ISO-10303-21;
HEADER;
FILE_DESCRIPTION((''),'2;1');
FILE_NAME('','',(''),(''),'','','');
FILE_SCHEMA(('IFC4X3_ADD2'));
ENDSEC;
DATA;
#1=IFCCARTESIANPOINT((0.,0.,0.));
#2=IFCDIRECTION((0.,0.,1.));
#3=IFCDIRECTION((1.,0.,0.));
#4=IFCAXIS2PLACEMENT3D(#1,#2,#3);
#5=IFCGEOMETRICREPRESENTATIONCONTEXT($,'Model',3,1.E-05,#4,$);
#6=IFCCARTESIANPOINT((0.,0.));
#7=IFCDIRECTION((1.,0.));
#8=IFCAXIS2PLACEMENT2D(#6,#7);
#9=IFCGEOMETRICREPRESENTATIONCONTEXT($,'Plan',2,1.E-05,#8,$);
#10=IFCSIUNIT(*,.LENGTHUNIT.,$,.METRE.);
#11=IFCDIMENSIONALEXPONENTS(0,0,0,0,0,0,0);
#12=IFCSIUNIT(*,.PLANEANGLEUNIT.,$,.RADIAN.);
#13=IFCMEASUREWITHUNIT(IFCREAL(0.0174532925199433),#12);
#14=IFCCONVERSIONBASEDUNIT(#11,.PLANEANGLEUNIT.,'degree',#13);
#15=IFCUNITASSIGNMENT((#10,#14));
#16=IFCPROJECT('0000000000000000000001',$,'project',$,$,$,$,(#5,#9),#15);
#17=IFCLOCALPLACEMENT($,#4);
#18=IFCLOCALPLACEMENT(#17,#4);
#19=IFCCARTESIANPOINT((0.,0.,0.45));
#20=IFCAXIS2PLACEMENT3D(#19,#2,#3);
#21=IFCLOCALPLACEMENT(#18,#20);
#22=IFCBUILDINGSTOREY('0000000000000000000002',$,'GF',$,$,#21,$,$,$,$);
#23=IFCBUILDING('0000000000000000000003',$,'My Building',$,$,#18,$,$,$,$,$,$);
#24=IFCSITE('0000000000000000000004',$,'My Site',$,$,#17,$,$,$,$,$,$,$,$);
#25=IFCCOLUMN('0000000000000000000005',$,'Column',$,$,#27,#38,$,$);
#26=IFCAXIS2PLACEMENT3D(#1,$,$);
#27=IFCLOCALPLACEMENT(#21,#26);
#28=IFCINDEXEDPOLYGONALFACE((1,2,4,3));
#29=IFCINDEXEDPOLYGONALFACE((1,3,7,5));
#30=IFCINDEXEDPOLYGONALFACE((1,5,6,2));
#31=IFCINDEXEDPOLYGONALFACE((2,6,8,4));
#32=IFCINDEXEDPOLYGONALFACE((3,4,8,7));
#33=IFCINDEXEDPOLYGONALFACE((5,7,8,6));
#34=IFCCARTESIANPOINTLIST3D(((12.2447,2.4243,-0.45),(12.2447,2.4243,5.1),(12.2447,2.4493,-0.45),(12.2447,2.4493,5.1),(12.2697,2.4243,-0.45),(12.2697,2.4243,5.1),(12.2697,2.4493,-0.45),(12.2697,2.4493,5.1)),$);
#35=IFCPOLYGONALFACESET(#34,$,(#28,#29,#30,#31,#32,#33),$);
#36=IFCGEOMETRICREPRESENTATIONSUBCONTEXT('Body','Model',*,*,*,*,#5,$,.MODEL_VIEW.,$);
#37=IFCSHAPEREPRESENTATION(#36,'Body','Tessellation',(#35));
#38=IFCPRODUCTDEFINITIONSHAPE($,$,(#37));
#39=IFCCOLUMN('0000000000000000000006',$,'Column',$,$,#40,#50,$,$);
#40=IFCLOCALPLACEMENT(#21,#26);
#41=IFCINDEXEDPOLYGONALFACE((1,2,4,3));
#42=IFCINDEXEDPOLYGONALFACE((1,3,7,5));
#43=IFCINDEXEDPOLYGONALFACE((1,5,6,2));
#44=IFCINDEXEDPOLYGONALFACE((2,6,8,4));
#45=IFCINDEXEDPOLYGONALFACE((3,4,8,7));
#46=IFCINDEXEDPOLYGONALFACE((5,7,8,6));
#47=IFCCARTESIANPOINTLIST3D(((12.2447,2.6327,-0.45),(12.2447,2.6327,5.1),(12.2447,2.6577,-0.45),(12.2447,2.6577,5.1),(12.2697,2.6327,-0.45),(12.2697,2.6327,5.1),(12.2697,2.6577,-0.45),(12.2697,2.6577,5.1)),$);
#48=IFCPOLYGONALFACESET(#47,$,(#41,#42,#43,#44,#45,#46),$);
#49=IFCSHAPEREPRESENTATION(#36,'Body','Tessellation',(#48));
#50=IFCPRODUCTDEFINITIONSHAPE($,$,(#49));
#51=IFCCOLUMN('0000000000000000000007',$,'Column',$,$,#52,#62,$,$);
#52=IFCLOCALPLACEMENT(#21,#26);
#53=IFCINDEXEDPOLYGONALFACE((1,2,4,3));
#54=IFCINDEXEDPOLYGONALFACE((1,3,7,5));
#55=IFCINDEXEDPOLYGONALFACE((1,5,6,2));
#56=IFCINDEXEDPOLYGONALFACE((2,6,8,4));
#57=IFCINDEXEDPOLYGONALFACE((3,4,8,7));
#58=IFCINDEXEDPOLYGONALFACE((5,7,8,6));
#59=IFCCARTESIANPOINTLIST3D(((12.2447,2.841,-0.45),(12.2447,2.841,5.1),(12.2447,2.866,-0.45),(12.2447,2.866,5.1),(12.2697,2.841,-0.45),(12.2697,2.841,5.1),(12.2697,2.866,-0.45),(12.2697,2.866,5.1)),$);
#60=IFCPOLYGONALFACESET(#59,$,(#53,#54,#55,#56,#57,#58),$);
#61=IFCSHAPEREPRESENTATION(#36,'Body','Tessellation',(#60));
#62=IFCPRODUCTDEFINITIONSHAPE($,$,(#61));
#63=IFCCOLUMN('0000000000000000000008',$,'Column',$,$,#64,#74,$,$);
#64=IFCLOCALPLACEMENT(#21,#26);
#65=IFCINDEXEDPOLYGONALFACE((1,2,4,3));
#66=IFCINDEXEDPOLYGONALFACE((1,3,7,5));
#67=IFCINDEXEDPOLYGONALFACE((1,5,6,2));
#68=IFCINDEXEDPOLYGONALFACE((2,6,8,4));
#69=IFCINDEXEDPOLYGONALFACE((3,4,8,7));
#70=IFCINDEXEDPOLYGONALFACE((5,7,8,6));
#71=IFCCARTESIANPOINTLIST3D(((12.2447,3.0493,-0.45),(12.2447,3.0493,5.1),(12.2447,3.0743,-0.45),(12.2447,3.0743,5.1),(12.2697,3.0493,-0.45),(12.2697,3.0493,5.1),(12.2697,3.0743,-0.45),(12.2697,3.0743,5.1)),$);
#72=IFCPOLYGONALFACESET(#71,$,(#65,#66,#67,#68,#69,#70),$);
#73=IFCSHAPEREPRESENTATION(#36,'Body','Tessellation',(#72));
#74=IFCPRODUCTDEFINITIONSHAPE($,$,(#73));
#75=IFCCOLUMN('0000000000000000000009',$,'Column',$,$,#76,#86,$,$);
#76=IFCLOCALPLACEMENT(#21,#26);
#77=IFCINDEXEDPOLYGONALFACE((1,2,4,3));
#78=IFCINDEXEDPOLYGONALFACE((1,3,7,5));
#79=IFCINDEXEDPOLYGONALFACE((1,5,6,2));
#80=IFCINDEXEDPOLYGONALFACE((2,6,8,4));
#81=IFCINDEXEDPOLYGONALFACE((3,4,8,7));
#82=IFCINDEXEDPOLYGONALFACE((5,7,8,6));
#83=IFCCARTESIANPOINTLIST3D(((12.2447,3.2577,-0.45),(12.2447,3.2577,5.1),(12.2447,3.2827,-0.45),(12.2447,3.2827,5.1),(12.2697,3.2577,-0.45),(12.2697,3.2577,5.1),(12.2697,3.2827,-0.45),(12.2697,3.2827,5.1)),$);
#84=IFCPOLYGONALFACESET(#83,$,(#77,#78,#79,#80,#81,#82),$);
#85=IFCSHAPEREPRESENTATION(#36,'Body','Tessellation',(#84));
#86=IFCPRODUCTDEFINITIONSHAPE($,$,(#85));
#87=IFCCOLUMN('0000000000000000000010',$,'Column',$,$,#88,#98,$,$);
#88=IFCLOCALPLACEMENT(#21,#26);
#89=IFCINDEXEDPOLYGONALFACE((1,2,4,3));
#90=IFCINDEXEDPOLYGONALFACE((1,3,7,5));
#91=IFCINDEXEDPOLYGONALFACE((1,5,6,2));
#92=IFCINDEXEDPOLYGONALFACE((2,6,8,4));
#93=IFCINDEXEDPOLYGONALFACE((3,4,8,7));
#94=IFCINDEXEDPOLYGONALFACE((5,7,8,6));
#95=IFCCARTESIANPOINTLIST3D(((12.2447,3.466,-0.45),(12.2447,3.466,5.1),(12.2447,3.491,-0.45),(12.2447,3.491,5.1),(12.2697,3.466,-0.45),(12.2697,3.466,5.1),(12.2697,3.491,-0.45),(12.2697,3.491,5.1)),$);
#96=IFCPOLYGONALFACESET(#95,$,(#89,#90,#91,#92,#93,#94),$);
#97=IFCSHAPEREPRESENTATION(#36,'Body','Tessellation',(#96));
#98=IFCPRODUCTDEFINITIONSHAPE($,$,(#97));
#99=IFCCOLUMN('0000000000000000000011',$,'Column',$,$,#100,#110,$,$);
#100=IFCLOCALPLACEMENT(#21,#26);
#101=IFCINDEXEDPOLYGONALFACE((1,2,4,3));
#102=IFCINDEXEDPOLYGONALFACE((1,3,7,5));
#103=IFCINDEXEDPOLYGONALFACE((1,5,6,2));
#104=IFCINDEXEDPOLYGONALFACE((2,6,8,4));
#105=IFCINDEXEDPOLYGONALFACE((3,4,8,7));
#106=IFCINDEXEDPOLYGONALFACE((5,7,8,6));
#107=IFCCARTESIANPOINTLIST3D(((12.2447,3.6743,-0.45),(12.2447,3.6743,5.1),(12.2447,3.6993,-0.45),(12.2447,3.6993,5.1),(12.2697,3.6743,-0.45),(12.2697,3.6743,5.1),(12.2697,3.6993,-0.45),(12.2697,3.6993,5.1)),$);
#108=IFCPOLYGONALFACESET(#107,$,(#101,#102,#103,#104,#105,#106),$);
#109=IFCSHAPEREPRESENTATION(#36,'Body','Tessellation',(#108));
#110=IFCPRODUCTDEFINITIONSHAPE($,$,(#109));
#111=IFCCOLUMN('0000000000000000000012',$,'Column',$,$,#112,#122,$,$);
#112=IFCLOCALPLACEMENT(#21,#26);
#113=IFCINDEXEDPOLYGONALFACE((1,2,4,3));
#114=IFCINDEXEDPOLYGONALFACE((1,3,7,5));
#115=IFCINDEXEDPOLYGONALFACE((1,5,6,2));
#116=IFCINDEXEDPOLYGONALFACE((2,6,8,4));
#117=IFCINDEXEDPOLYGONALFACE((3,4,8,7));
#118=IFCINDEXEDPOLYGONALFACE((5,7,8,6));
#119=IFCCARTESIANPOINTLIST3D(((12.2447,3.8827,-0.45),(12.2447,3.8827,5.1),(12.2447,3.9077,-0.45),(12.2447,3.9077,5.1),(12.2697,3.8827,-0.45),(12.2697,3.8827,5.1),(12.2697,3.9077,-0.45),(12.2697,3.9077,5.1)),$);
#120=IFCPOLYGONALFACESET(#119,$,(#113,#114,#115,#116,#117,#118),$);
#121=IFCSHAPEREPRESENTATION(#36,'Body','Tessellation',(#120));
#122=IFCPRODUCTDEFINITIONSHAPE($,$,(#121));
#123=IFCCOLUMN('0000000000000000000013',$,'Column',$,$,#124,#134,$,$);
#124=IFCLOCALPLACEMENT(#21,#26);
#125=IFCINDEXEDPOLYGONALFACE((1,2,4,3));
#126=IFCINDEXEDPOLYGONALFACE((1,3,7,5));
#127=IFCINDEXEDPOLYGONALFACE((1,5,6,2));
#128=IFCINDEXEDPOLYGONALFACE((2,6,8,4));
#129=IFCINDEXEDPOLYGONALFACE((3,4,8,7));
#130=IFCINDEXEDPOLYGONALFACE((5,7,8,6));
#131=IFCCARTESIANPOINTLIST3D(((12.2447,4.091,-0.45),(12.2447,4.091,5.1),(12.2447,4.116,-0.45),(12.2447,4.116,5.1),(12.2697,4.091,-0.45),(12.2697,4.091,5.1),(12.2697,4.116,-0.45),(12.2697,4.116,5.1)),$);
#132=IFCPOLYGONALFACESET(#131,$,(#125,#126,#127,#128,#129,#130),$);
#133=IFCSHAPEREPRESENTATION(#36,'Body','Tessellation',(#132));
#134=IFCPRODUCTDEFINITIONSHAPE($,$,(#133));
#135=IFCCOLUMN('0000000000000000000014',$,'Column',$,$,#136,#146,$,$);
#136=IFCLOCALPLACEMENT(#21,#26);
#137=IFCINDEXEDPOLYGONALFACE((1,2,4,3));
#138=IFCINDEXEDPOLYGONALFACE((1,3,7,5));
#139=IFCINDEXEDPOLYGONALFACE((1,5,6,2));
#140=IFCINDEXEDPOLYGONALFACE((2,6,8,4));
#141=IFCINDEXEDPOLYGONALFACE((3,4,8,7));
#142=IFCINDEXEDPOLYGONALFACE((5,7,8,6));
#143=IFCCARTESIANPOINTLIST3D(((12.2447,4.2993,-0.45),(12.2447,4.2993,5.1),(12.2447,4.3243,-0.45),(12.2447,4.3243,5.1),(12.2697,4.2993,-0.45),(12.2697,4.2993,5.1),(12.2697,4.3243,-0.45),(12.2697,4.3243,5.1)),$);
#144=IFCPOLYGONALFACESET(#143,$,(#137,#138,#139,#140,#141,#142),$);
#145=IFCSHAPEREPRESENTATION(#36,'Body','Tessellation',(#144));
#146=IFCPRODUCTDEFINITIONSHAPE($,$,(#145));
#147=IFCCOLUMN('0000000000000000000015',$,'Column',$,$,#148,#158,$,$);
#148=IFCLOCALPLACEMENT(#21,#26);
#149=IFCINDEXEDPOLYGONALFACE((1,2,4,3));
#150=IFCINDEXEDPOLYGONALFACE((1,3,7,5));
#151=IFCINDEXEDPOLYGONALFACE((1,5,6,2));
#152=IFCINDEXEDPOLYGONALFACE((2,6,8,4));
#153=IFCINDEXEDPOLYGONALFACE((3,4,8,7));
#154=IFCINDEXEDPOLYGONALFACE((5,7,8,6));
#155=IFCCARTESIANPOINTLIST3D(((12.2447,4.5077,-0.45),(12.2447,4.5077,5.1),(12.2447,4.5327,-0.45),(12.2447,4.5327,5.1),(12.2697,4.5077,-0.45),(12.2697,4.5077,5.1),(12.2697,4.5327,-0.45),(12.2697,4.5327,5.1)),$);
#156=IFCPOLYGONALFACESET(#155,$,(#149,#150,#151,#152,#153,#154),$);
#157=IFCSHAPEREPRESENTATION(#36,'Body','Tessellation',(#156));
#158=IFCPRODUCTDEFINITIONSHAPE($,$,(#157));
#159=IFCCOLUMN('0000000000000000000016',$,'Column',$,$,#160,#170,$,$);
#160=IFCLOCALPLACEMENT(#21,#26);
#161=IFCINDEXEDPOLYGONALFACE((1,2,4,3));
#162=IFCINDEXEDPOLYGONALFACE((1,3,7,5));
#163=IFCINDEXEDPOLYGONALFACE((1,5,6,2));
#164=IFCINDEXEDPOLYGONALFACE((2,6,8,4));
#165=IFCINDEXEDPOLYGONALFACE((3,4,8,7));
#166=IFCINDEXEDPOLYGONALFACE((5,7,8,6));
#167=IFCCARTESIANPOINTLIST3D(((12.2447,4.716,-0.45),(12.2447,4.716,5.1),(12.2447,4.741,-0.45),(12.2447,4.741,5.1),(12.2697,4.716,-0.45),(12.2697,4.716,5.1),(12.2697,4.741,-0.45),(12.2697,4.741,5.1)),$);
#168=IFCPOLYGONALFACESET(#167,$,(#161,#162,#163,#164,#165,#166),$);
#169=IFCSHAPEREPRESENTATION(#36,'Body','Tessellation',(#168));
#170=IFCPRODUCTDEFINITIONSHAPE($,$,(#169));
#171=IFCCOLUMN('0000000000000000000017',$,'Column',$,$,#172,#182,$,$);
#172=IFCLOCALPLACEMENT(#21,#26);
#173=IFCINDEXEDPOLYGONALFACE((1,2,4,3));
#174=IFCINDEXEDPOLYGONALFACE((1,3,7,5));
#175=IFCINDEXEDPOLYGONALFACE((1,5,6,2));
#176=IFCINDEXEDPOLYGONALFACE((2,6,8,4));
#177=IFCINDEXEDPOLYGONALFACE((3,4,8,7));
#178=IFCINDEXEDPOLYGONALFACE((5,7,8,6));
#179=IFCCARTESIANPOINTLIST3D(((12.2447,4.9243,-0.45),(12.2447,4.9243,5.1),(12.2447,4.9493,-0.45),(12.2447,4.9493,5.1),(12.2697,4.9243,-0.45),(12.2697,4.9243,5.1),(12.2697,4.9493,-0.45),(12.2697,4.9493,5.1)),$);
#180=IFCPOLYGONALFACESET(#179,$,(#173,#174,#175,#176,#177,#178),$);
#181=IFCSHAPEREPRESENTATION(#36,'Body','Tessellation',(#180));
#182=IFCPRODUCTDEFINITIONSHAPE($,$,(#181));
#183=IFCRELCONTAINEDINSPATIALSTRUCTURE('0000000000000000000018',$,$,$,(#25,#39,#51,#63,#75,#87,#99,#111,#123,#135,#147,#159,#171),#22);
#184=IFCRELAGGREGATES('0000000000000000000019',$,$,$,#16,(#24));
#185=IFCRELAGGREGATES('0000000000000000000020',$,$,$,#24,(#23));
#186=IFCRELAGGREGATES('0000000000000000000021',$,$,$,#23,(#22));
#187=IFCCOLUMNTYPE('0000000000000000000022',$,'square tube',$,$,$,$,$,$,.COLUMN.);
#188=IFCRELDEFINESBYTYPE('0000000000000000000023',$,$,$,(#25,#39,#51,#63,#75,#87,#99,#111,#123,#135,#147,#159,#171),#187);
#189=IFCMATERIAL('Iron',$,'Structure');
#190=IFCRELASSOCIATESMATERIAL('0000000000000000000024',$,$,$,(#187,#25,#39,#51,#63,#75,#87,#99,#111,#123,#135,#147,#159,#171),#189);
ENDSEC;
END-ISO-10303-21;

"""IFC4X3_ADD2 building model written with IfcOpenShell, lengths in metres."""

from ifc_helpers import new_model, entity, si_unit, converted_unit, frame, origin_with_axes, origin_2d_with_axis, place, context, subcontext, project, spatial, indexed_curve, outline, extrude, material, material_profile, profile_set, profile_usage, type_object, element, save


model = new_model("IFC4X3_ADD2")

# Units and contexts
model_context = context("Model", 3, precision=1e-05, world=origin_with_axes())
plan_context = context("Plan", 2, precision=1e-05, world=origin_2d_with_axis())
body_context = subcontext(model_context, "Body", "Model", "MODEL_VIEW")
ifc_project = project(units=[si_unit("LENGTHUNIT", "METRE"), converted_unit("PLANEANGLEUNIT", "degree", entity("IfcReal", 0.0174532925199433), si_unit("PLANEANGLEUNIT", "RADIAN"), dimensions=[0, 0, 0, 0, 0, 0, 0])], contexts=[model_context, plan_context])

# Site, building, storey
site_placement = place(None, origin_with_axes())
site = spatial("IfcSite", under=ifc_project, at=site_placement, Name="My Site")
building_placement = place(site_placement, origin_with_axes())
building = spatial("IfcBuilding", under=site, at=building_placement, Name="My Building")
storey_placement = place(building_placement, frame((0.0, 0.0, 0.45), z_axis=(0.0, 0.0, 1.0), x_axis=(1.0, 0.0, 0.0)))
storey = spatial("IfcBuildingStorey", under=building, at=storey_placement, Name="GF")

# Columns
ifc_material_1 = material(Name="Iron", Category="Structure")
ifc_material_profile = material_profile(ifc_material_1, outline(indexed_curve([(-0.0125, -0.0125), (0.0125, -0.0125), (0.0125, 0.0125), (-0.0125, 0.0125), (-0.0125, -0.0125)])))
ifc_profile_set = profile_set([ifc_material_profile])
ifc_profile_usage_1 = profile_usage(ifc_profile_set, cardinal=5)
column_type = type_object("IfcColumnType", Name="square tube", PredefinedType="COLUMN", material=ifc_profile_set)
column_1_placement = place(storey_placement, frame((12.2572, 2.4368, -0.45), z_axis=(0.0, 0.0, 1.0), x_axis=(0.0, 1.0, 0.0)))
element("IfcColumn", 1, at=column_1_placement, inside=storey, type_object=column_type, material=ifc_profile_usage_1, Name="Column", context=body_context, shape_type="SweptSolid", body=[
    extrude(outline(indexed_curve([(-0.0125, -0.0125), (0.0125, -0.0125), (0.0125, 0.0125), (-0.0125, 0.0125), (-0.0125, -0.0125)])), origin_with_axes(), (0.0, 0.0, 1.0), 5.55),
])
ifc_profile_usage_2 = profile_usage(ifc_profile_set, cardinal=5)
column_2_placement = place(storey_placement, frame((12.2572, 2.6452, -0.45), z_axis=(0.0, 0.0, 1.0), x_axis=(0.0, 1.0, 0.0)))
element("IfcColumn", 2, at=column_2_placement, inside=storey, type_object=column_type, material=ifc_profile_usage_2, Name="Column", context=body_context, shape_type="SweptSolid", body=[
    extrude(outline(indexed_curve([(-0.0125, -0.0125), (0.0125, -0.0125), (0.0125, 0.0125), (-0.0125, 0.0125), (-0.0125, -0.0125)])), origin_with_axes(), (0.0, 0.0, 1.0), 5.55),
])
ifc_profile_usage_3 = profile_usage(ifc_profile_set, cardinal=5)
column_3_placement = place(storey_placement, frame((12.2572, 2.8535, -0.45), z_axis=(0.0, 0.0, 1.0), x_axis=(0.0, 1.0, 0.0)))
element("IfcColumn", 3, at=column_3_placement, inside=storey, type_object=column_type, material=ifc_profile_usage_3, Name="Column", context=body_context, shape_type="SweptSolid", body=[
    extrude(outline(indexed_curve([(-0.0125, -0.0125), (0.0125, -0.0125), (0.0125, 0.0125), (-0.0125, 0.0125), (-0.0125, -0.0125)])), origin_with_axes(), (0.0, 0.0, 1.0), 5.55),
])
ifc_profile_usage_4 = profile_usage(ifc_profile_set, cardinal=5)
column_4_placement = place(storey_placement, frame((12.2572, 3.0618, -0.45), z_axis=(0.0, 0.0, 1.0), x_axis=(0.0, 1.0, 0.0)))
element("IfcColumn", 4, at=column_4_placement, inside=storey, type_object=column_type, material=ifc_profile_usage_4, Name="Column", context=body_context, shape_type="SweptSolid", body=[
    extrude(outline(indexed_curve([(-0.0125, -0.0125), (0.0125, -0.0125), (0.0125, 0.0125), (-0.0125, 0.0125), (-0.0125, -0.0125)])), origin_with_axes(), (0.0, 0.0, 1.0), 5.55),
])
ifc_profile_usage_5 = profile_usage(ifc_profile_set, cardinal=5)
column_5_placement = place(storey_placement, frame((12.2572, 3.2702, -0.45), z_axis=(0.0, 0.0, 1.0), x_axis=(0.0, 1.0, 0.0)))
element("IfcColumn", 5, at=column_5_placement, inside=storey, type_object=column_type, material=ifc_profile_usage_5, Name="Column", context=body_context, shape_type="SweptSolid", body=[
    extrude(outline(indexed_curve([(-0.0125, -0.0125), (0.0125, -0.0125), (0.0125, 0.0125), (-0.0125, 0.0125), (-0.0125, -0.0125)])), origin_with_axes(), (0.0, 0.0, 1.0), 5.55),
])
ifc_profile_usage_6 = profile_usage(ifc_profile_set, cardinal=5)
column_6_placement = place(storey_placement, frame((12.2572, 3.4785, -0.45), z_axis=(0.0, 0.0, 1.0), x_axis=(0.0, 1.0, 0.0)))
element("IfcColumn", 6, at=column_6_placement, inside=storey, type_object=column_type, material=ifc_profile_usage_6, Name="Column", context=body_context, shape_type="SweptSolid", body=[
    extrude(outline(indexed_curve([(-0.0125, -0.0125), (0.0125, -0.0125), (0.0125, 0.0125), (-0.0125, 0.0125), (-0.0125, -0.0125)])), origin_with_axes(), (0.0, 0.0, 1.0), 5.55),
])
ifc_profile_usage_7 = profile_usage(ifc_profile_set, cardinal=5)
column_7_placement = place(storey_placement, frame((12.2572, 3.6868, -0.45), z_axis=(0.0, 0.0, 1.0), x_axis=(0.0, 1.0, 0.0)))
element("IfcColumn", 7, at=column_7_placement, inside=storey, type_object=column_type, material=ifc_profile_usage_7, Name="Column", context=body_context, shape_type="SweptSolid", body=[
    extrude(outline(indexed_curve([(-0.0125, -0.0125), (0.0125, -0.0125), (0.0125, 0.0125), (-0.0125, 0.0125), (-0.0125, -0.0125)])), origin_with_axes(), (0.0, 0.0, 1.0), 5.55),
])
ifc_profile_usage_8 = profile_usage(ifc_profile_set, cardinal=5)
column_8_placement = place(storey_placement, frame((12.2572, 3.8952, -0.45), z_axis=(0.0, 0.0, 1.0), x_axis=(0.0, 1.0, 0.0)))
element("IfcColumn", 8, at=column_8_placement, inside=storey, type_object=column_type, material=ifc_profile_usage_8, Name="Column", context=body_context, shape_type="SweptSolid", body=[
    extrude(outline(indexed_curve([(-0.0125, -0.0125), (0.0125, -0.0125), (0.0125, 0.0125), (-0.0125, 0.0125), (-0.0125, -0.0125)])), origin_with_axes(), (0.0, 0.0, 1.0), 5.55),
])
ifc_profile_usage_9 = profile_usage(ifc_profile_set, cardinal=5)
column_9_placement = place(storey_placement, frame((12.2572, 4.1035, -0.45), z_axis=(0.0, 0.0, 1.0), x_axis=(0.0, 1.0, 0.0)))
element("IfcColumn", 9, at=column_9_placement, inside=storey, type_object=column_type, material=ifc_profile_usage_9, Name="Column", context=body_context, shape_type="SweptSolid", body=[
    extrude(outline(indexed_curve([(-0.0125, -0.0125), (0.0125, -0.0125), (0.0125, 0.0125), (-0.0125, 0.0125), (-0.0125, -0.0125)])), origin_with_axes(), (0.0, 0.0, 1.0), 5.55),
])
ifc_profile_usage_10 = profile_usage(ifc_profile_set, cardinal=5)
column_10_placement = place(storey_placement, frame((12.2572, 4.3118, -0.45), z_axis=(0.0, 0.0, 1.0), x_axis=(0.0, 1.0, 0.0)))
element("IfcColumn", 10, at=column_10_placement, inside=storey, type_object=column_type, material=ifc_profile_usage_10, Name="Column", context=body_context, shape_type="SweptSolid", body=[
    extrude(outline(indexed_curve([(-0.0125, -0.0125), (0.0125, -0.0125), (0.0125, 0.0125), (-0.0125, 0.0125), (-0.0125, -0.0125)])), origin_with_axes(), (0.0, 0.0, 1.0), 5.55),
])
ifc_profile_usage_11 = profile_usage(ifc_profile_set, cardinal=5)
column_11_placement = place(storey_placement, frame((12.2572, 4.5202, -0.45), z_axis=(0.0, 0.0, 1.0), x_axis=(0.0, 1.0, 0.0)))
element("IfcColumn", 11, at=column_11_placement, inside=storey, type_object=column_type, material=ifc_profile_usage_11, Name="Column", context=body_context, shape_type="SweptSolid", body=[
    extrude(outline(indexed_curve([(-0.0125, -0.0125), (0.0125, -0.0125), (0.0125, 0.0125), (-0.0125, 0.0125), (-0.0125, -0.0125)])), origin_with_axes(), (0.0, 0.0, 1.0), 5.55),
])
ifc_profile_usage_12 = profile_usage(ifc_profile_set, cardinal=5)
column_12_placement = place(storey_placement, frame((12.2572, 4.7285, -0.45), z_axis=(0.0, 0.0, 1.0), x_axis=(0.0, 1.0, 0.0)))
element("IfcColumn", 12, at=column_12_placement, inside=storey, type_object=column_type, material=ifc_profile_usage_12, Name="Column", context=body_context, shape_type="SweptSolid", body=[
    extrude(outline(indexed_curve([(-0.0125, -0.0125), (0.0125, -0.0125), (0.0125, 0.0125), (-0.0125, 0.0125), (-0.0125, -0.0125)])), origin_with_axes(), (0.0, 0.0, 1.0), 5.55),
])
ifc_profile_usage_13 = profile_usage(ifc_profile_set, cardinal=5)
column_13_placement = place(storey_placement, frame((12.2572, 4.9368, -0.45), z_axis=(0.0, 0.0, 1.0), x_axis=(0.0, 1.0, 0.0)))
element("IfcColumn", 13, at=column_13_placement, inside=storey, type_object=column_type, material=ifc_profile_usage_13, Name="Column", context=body_context, shape_type="SweptSolid", body=[
    extrude(outline(indexed_curve([(-0.0125, -0.0125), (0.0125, -0.0125), (0.0125, 0.0125), (-0.0125, 0.0125), (-0.0125, -0.0125)])), origin_with_axes(), (0.0, 0.0, 1.0), 5.55),
])

save(model, "model.ifc")
